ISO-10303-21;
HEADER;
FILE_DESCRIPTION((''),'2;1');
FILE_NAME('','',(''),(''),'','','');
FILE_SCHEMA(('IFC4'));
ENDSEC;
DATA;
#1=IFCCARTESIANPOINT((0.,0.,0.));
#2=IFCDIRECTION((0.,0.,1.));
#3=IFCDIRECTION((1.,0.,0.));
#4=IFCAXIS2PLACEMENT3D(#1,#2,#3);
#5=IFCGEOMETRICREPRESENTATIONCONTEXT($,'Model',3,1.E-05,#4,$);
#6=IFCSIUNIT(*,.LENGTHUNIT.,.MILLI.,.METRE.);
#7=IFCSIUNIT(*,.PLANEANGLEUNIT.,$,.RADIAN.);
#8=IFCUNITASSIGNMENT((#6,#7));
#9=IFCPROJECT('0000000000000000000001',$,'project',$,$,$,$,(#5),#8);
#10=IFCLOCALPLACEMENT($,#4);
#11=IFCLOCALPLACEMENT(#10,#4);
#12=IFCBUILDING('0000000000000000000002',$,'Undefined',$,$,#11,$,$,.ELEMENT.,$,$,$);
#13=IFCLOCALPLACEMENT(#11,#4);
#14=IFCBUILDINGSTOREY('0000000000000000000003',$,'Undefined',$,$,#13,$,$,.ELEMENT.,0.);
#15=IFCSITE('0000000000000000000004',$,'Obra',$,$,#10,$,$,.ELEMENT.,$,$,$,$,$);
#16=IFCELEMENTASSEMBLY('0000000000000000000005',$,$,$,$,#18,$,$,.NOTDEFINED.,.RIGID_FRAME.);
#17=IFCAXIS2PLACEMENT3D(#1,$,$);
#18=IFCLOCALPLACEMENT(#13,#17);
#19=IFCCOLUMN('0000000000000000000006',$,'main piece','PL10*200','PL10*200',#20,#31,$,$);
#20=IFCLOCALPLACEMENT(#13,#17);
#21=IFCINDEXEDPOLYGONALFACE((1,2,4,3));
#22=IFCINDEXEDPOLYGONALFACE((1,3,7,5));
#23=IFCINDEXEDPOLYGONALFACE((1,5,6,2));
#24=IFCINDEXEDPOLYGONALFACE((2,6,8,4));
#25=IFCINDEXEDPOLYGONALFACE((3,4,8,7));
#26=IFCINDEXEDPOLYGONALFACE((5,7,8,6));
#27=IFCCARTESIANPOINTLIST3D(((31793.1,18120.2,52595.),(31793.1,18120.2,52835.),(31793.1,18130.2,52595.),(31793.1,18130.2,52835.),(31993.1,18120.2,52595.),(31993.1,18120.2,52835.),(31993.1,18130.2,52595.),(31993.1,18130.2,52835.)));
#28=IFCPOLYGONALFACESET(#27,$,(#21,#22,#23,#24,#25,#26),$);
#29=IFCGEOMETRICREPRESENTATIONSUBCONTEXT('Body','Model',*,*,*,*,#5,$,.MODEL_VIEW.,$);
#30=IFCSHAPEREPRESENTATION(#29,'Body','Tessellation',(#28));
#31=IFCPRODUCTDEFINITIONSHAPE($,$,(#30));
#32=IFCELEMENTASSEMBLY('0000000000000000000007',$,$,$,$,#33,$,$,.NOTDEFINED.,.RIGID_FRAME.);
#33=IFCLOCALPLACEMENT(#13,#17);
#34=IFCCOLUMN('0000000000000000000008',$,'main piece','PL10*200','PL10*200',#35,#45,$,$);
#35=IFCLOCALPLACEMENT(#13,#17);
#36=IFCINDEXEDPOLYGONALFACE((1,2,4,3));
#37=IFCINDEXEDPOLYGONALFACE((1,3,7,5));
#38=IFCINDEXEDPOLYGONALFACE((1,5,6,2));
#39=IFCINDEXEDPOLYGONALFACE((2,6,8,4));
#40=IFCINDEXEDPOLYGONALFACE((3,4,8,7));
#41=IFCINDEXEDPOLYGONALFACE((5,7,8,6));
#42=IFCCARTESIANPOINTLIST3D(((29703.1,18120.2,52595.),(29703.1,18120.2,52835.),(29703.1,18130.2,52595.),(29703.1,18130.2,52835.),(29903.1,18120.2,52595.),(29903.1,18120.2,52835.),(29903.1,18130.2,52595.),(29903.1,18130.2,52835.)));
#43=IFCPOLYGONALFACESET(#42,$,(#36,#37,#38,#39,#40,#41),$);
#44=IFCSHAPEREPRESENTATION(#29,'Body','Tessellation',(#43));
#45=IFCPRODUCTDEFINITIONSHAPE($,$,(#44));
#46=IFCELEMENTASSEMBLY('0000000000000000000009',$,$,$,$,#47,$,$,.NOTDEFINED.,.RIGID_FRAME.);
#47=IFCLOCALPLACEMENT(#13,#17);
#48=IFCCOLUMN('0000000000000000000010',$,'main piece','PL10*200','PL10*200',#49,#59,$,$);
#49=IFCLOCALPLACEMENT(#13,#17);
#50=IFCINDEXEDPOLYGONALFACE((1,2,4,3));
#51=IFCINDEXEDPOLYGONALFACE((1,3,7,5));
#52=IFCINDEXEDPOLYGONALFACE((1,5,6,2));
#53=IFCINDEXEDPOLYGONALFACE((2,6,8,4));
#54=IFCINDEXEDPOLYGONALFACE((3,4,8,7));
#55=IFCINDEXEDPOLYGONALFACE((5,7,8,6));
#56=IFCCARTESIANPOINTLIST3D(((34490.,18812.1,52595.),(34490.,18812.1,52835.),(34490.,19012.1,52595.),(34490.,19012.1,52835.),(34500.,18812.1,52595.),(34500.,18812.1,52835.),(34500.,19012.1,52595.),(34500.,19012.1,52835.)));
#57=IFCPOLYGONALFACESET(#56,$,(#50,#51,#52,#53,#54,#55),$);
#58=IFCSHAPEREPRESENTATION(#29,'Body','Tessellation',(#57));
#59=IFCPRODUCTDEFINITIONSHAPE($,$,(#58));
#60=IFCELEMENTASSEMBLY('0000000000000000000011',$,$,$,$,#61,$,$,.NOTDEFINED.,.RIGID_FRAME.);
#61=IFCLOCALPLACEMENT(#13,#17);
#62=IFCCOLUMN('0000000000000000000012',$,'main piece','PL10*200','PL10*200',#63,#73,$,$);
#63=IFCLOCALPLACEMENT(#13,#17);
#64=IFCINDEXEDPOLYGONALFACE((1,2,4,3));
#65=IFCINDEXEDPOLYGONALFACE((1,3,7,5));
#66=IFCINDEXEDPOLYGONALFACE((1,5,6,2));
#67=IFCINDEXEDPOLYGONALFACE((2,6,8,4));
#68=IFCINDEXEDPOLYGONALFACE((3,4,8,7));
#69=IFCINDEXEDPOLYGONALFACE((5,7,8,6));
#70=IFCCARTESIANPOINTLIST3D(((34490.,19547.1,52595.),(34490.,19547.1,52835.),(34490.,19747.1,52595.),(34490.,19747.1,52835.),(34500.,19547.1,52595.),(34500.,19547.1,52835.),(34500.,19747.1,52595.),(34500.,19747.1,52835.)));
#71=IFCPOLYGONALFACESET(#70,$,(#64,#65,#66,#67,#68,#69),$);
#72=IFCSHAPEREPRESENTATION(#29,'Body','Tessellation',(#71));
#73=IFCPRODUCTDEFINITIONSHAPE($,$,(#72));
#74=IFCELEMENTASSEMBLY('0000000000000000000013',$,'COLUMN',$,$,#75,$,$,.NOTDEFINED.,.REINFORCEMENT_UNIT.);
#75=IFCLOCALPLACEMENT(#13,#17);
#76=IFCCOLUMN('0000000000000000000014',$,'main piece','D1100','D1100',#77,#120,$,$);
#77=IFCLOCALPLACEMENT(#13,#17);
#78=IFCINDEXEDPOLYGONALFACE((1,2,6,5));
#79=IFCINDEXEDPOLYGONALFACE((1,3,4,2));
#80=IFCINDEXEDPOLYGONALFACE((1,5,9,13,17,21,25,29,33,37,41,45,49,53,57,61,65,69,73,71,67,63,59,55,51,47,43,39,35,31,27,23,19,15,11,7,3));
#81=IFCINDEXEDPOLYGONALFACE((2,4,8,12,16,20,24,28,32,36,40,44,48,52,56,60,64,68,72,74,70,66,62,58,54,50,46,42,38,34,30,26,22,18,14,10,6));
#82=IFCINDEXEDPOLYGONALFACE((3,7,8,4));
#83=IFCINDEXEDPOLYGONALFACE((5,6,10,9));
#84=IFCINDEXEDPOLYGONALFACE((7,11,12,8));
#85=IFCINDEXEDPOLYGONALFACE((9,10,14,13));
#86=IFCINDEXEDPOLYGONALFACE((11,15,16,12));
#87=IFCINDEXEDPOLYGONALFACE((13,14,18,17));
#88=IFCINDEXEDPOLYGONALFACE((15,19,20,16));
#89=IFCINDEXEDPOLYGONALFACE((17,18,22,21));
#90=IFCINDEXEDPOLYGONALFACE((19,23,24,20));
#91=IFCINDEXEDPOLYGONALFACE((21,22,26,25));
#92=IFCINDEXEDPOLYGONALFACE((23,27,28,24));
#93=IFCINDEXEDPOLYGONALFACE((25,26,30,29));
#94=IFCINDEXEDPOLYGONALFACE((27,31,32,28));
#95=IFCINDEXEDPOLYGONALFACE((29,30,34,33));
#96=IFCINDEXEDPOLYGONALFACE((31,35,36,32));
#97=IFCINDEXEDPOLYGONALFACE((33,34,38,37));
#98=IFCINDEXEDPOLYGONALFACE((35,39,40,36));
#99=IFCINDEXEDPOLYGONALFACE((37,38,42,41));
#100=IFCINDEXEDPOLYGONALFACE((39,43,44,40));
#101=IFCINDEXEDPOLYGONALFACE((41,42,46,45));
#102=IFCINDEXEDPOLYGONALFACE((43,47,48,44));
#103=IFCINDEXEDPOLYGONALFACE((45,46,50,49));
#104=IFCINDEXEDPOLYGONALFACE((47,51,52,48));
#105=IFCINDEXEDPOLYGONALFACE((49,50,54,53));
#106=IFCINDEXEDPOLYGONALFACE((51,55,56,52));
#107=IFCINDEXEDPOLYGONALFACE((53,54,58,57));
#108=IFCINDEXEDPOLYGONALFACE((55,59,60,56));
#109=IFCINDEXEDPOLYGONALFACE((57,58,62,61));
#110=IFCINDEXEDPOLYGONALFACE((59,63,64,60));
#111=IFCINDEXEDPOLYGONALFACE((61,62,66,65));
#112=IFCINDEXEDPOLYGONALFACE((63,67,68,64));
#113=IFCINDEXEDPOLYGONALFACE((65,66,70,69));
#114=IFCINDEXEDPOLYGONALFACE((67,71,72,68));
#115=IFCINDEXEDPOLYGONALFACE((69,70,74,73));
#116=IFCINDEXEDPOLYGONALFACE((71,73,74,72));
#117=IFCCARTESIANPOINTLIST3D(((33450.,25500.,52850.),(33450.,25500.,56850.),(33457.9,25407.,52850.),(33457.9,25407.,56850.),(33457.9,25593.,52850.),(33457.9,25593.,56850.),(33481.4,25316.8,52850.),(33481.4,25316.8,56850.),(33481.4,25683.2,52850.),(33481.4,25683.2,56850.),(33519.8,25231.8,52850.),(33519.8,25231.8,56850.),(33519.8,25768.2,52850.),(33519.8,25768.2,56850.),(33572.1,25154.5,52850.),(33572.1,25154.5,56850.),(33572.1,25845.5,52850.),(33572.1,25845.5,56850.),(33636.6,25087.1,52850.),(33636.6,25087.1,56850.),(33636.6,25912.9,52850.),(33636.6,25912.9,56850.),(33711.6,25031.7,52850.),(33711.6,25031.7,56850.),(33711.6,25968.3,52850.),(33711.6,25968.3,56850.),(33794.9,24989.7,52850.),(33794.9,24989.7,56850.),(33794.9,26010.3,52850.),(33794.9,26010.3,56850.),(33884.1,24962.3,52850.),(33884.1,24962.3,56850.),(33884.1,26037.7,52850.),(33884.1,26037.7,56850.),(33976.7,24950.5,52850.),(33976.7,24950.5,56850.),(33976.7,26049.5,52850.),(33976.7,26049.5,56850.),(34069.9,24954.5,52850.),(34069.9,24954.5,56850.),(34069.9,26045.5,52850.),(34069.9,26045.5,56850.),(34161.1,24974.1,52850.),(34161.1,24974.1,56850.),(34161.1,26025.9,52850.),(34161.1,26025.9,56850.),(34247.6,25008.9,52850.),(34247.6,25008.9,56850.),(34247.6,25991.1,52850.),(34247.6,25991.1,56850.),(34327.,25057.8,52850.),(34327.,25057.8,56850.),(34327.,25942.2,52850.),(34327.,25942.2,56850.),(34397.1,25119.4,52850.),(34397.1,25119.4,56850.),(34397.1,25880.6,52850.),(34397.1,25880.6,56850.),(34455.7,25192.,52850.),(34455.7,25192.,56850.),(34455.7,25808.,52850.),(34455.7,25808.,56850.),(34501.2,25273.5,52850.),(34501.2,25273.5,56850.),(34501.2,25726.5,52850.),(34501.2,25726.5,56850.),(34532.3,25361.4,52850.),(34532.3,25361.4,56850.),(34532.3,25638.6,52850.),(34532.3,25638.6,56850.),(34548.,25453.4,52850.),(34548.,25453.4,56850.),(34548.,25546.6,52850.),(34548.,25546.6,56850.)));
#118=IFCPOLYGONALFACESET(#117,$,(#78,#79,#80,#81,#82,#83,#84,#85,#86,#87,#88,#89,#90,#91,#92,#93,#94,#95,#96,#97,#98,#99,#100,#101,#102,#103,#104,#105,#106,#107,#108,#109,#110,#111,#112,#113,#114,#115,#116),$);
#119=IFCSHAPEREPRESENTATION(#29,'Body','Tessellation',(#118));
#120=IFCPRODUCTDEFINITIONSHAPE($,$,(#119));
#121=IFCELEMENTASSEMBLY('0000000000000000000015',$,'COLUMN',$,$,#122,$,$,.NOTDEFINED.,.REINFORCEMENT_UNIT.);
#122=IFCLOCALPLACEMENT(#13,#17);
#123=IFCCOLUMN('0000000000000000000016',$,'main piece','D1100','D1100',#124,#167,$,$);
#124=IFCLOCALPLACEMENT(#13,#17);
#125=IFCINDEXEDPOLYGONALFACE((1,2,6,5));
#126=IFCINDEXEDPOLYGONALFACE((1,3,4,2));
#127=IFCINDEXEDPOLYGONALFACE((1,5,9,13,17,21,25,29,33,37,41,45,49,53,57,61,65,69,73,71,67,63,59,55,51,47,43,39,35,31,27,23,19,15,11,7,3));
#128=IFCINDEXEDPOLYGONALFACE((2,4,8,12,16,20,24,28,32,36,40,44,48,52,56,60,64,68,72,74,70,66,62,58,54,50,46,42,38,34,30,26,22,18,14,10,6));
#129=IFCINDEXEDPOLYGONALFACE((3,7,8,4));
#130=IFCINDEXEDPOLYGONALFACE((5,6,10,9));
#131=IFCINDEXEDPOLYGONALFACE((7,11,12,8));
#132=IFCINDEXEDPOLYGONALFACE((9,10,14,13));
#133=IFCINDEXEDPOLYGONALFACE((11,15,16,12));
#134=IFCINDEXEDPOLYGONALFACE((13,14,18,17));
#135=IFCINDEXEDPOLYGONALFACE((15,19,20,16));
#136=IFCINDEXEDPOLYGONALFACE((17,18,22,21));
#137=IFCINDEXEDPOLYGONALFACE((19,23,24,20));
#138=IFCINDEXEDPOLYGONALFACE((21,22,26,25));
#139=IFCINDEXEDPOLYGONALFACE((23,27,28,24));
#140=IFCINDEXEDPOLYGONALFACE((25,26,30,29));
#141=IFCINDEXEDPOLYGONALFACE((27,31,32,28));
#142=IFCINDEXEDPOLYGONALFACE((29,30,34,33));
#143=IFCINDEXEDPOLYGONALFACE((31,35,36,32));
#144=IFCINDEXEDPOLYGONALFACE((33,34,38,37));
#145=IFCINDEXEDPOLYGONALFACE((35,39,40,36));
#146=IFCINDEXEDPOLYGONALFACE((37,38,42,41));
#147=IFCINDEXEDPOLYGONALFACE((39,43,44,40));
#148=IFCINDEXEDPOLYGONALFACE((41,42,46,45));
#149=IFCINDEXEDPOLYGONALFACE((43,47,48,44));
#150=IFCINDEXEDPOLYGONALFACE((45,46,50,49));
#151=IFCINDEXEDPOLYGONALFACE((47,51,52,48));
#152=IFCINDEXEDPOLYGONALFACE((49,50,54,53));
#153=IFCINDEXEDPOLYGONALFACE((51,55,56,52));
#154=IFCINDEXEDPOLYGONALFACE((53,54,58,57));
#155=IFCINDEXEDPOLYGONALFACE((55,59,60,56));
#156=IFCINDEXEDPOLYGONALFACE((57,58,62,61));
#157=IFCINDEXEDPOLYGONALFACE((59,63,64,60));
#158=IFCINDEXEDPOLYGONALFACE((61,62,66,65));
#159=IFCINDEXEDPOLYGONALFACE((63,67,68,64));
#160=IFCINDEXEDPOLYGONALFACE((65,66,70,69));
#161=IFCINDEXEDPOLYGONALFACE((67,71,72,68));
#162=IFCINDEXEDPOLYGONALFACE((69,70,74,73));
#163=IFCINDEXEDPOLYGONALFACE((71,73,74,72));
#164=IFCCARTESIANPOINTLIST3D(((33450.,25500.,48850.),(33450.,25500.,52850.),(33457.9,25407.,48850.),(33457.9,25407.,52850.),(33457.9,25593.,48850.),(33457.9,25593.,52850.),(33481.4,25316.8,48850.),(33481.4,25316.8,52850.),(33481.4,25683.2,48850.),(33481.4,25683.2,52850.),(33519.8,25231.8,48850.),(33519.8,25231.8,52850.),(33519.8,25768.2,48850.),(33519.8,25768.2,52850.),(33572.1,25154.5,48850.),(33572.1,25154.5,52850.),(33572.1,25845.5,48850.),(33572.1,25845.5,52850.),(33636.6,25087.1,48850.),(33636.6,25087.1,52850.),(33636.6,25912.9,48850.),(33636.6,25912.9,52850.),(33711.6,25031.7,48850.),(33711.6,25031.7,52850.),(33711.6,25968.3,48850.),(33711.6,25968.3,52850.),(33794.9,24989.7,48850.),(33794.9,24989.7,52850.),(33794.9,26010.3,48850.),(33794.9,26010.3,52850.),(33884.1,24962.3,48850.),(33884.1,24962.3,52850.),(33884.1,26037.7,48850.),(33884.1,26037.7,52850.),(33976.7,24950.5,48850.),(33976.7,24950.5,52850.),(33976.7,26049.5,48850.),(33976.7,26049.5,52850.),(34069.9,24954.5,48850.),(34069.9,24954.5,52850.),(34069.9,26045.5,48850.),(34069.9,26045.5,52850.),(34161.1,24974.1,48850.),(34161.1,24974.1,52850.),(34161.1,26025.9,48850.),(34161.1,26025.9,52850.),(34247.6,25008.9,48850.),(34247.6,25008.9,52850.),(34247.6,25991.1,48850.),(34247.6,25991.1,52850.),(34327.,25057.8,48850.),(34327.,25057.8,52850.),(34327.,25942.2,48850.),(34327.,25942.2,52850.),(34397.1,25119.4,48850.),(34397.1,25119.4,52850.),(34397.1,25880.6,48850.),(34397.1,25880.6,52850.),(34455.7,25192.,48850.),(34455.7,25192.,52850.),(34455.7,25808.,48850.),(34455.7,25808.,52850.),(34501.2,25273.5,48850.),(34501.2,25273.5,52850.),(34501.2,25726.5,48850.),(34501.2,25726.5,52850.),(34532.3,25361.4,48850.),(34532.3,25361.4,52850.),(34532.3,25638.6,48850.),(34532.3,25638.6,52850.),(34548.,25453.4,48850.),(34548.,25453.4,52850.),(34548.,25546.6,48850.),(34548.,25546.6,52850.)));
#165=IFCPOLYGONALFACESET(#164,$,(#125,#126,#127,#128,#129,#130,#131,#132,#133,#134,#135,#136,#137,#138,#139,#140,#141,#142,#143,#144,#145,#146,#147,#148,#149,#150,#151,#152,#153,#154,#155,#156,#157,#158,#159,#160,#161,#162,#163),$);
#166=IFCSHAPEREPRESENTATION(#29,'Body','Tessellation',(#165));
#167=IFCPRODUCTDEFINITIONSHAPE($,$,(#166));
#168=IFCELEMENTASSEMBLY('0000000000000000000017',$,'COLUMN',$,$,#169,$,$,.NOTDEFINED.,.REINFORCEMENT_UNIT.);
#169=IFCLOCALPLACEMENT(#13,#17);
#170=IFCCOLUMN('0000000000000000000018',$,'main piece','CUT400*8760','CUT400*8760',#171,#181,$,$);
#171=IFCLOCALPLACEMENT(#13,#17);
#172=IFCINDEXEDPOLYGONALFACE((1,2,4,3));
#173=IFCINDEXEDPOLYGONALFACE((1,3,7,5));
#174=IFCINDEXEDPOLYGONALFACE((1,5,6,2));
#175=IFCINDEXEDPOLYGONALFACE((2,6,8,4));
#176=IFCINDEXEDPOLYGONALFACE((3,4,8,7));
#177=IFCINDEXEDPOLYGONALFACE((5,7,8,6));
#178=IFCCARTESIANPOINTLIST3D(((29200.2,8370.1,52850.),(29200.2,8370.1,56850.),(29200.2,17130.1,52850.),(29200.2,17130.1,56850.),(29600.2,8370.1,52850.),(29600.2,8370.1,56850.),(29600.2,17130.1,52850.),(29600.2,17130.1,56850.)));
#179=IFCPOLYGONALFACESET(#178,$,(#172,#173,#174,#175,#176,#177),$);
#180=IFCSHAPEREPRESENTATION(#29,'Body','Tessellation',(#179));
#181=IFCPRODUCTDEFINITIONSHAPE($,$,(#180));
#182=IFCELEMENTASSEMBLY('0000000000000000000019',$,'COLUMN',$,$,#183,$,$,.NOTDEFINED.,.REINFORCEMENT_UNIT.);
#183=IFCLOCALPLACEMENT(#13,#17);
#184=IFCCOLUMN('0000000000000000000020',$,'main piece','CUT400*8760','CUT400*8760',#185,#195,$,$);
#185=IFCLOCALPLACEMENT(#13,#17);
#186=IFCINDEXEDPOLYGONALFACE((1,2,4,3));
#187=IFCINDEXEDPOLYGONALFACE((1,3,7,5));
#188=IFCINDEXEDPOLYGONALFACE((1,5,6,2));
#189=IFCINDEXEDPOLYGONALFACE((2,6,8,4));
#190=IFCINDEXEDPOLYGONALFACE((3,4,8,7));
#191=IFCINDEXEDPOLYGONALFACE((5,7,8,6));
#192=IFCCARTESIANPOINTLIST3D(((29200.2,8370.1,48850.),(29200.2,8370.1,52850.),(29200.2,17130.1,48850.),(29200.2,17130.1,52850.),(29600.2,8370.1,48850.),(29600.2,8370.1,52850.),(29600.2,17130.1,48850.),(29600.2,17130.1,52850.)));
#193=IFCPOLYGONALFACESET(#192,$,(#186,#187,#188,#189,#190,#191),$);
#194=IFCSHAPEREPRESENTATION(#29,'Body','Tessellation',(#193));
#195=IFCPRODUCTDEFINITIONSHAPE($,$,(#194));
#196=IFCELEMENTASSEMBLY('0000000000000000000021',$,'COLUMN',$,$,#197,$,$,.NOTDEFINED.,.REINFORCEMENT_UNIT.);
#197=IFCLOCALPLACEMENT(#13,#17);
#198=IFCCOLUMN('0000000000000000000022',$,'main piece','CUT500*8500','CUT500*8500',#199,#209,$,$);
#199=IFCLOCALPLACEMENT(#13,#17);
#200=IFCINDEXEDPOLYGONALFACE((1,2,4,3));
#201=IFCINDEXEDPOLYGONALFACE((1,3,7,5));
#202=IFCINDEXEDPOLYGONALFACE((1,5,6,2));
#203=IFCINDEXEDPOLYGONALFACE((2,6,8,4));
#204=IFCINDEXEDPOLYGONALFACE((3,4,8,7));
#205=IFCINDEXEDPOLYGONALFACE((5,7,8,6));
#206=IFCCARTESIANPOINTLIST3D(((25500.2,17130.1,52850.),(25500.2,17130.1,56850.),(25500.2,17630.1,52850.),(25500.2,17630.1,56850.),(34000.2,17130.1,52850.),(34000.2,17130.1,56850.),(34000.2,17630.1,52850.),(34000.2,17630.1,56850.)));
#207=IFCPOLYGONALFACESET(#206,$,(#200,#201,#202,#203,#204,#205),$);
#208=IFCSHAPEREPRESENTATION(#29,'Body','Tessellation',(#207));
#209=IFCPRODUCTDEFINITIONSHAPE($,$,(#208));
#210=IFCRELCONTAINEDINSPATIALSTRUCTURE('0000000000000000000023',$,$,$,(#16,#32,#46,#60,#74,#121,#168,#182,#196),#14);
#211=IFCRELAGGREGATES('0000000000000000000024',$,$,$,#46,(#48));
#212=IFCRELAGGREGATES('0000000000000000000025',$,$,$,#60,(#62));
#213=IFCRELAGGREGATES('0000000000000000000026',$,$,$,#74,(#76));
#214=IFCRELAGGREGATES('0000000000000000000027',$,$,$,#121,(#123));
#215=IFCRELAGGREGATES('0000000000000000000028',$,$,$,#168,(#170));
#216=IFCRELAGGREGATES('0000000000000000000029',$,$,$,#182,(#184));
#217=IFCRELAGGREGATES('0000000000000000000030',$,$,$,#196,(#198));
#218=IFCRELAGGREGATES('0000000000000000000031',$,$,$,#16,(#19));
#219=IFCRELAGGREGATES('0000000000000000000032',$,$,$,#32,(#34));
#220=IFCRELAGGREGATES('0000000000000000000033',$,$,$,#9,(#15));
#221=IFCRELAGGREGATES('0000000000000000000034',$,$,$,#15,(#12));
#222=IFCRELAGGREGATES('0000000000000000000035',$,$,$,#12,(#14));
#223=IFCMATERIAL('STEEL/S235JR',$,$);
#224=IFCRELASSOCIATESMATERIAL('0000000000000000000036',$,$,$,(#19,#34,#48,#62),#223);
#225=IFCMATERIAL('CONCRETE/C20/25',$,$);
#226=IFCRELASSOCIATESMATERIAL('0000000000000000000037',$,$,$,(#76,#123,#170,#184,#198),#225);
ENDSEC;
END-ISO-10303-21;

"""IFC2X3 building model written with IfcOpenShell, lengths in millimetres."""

from ifc_helpers import new_model, si_unit, frame, origin_with_axes, origin_2d_with_axis, place, context, subcontext, project, spatial, rectangle, circle, extrude, material, element, aggregate, save


model = new_model("IFC2X3")

# Units and contexts
model_context = context("Model", 3, precision=1e-05, world=origin_with_axes())
body_context = subcontext(model_context, "Body", "Model", "MODEL_VIEW")
ifc_project = project(units=[si_unit("LENGTHUNIT", "METRE", prefix="MILLI"), si_unit("PLANEANGLEUNIT", "RADIAN")], contexts=[model_context])

# Site, building, storey
site_placement = place(None, origin_with_axes())
site = spatial("IfcSite", under=ifc_project, at=site_placement, Name="Obra", CompositionType="ELEMENT")
building_placement = place(site_placement, origin_with_axes())
building = spatial("IfcBuilding", under=site, at=building_placement, Name="Undefined", CompositionType="ELEMENT")
storey_placement = place(building_placement, origin_with_axes())
storey = spatial("IfcBuildingStorey", under=building, at=storey_placement, Name="Undefined", CompositionType="ELEMENT", Elevation=0.0)

# Element assemblies, columns
assembly_1_placement = place(storey_placement, origin_with_axes())
assembly_1 = element("IfcElementAssembly", 1, at=assembly_1_placement, inside=storey, AssemblyPlace="NOTDEFINED", PredefinedType="RIGID_FRAME")
ifc_material_1 = material(Name="STEEL/S235JR")
column_1_placement = place(assembly_1_placement, frame((31893.1, 18125.2, 52595.0), z_axis=(0.0, 0.0, 1.0), x_axis=(1.0, 0.000002, 0.0)))
column_1 = element("IfcColumn", 2, at=column_1_placement, material=ifc_material_1, Name="main piece", Description="PL10*200", ObjectType="PL10*200", context=body_context, shape_type="SweptSolid", body=[
    extrude(rectangle(XDim=10.0, YDim=200.0, at=origin_2d_with_axis()), frame((0.0, 0.0, 240.0), z_axis=(0.0, 0.0, -1.0), x_axis=(0.0, 1.0, 0.0)), (0.0, 0.0, 1.0), 240.0),
])
assembly_2_placement = place(storey_placement, origin_with_axes())
assembly_2 = element("IfcElementAssembly", 3, at=assembly_2_placement, inside=storey, AssemblyPlace="NOTDEFINED", PredefinedType="RIGID_FRAME")
column_2_placement = place(assembly_2_placement, frame((29803.1, 18125.2, 52595.0), z_axis=(0.0, 0.0, 1.0), x_axis=(1.0, 0.000002, 0.0)))
column_2 = element("IfcColumn", 4, at=column_2_placement, material=ifc_material_1, Name="main piece", Description="PL10*200", ObjectType="PL10*200", context=body_context, shape_type="SweptSolid", body=[
    extrude(rectangle(XDim=10.0, YDim=200.0, at=origin_2d_with_axis()), frame((0.0, 0.0, 240.0), z_axis=(0.0, 0.0, -1.0), x_axis=(0.0, 1.0, 0.0)), (0.0, 0.0, 1.0), 240.0),
])
assembly_3_placement = place(storey_placement, origin_with_axes())
assembly_3 = element("IfcElementAssembly", 5, at=assembly_3_placement, inside=storey, AssemblyPlace="NOTDEFINED", PredefinedType="RIGID_FRAME")
column_3_placement = place(assembly_3_placement, frame((34495.0, 18912.1, 52595.0), z_axis=(0.0, 0.0, 1.0), x_axis=(0.0, -1.0, 0.0)))
column_3 = element("IfcColumn", 6, at=column_3_placement, material=ifc_material_1, Name="main piece", Description="PL10*200", ObjectType="PL10*200", context=body_context, shape_type="SweptSolid", body=[
    extrude(rectangle(XDim=10.0, YDim=200.0, at=origin_2d_with_axis()), frame((0.0, 0.0, 240.0), z_axis=(0.0, 0.0, -1.0), x_axis=(0.0, 1.0, 0.0)), (0.0, 0.0, 1.0), 240.0),
])
aggregate(assembly_3, [column_3])
assembly_4_placement = place(storey_placement, origin_with_axes())
assembly_4 = element("IfcElementAssembly", 7, at=assembly_4_placement, inside=storey, AssemblyPlace="NOTDEFINED", PredefinedType="RIGID_FRAME")
column_4_placement = place(assembly_4_placement, frame((34495.0, 19647.1, 52595.0), z_axis=(0.0, 0.0, 1.0), x_axis=(0.0, -1.0, 0.0)))
column_4 = element("IfcColumn", 8, at=column_4_placement, material=ifc_material_1, Name="main piece", Description="PL10*200", ObjectType="PL10*200", context=body_context, shape_type="SweptSolid", body=[
    extrude(rectangle(XDim=10.0, YDim=200.0, at=origin_2d_with_axis()), frame((0.0, 0.0, 240.0), z_axis=(0.0, 0.0, -1.0), x_axis=(0.0, 1.0, 0.0)), (0.0, 0.0, 1.0), 240.0),
])
aggregate(assembly_4, [column_4])
assembly_5_placement = place(storey_placement, origin_with_axes())
assembly_5 = element("IfcElementAssembly", 9, at=assembly_5_placement, inside=storey, Name="COLUMN", AssemblyPlace="NOTDEFINED", PredefinedType="REINFORCEMENT_UNIT")
ifc_material_2 = material(Name="CONCRETE/C20/25")
column_5_placement = place(assembly_5_placement, frame((34000.0, 25500.0, 52850.0), z_axis=(0.0, 0.0, 1.0), x_axis=(0.0, 1.0, 0.0)))
column_5 = element("IfcColumn", 10, at=column_5_placement, material=ifc_material_2, Name="main piece", Description="D1100", ObjectType="D1100", context=body_context, shape_type="SweptSolid", body=[
    extrude(circle(Radius=550.0, at=origin_2d_with_axis()), frame((0.0, 0.0, 4000.0), z_axis=(0.0, 0.0, -1.0), x_axis=(0.0, 1.0, 0.0)), (0.0, 0.0, 1.0), 4000.0),
])
aggregate(assembly_5, [column_5])
assembly_6_placement = place(storey_placement, origin_with_axes())
assembly_6 = element("IfcElementAssembly", 11, at=assembly_6_placement, inside=storey, Name="COLUMN", AssemblyPlace="NOTDEFINED", PredefinedType="REINFORCEMENT_UNIT")
column_6_placement = place(assembly_6_placement, frame((34000.0, 25500.0, 48850.0), z_axis=(0.0, 0.0, 1.0), x_axis=(0.0, 1.0, 0.0)))
column_6 = element("IfcColumn", 12, at=column_6_placement, material=ifc_material_2, Name="main piece", Description="D1100", ObjectType="D1100", context=body_context, shape_type="SweptSolid", body=[
    extrude(circle(Radius=550.0, at=origin_2d_with_axis()), frame((0.0, 0.0, 4000.0), z_axis=(0.0, 0.0, -1.0), x_axis=(0.0, 1.0, 0.0)), (0.0, 0.0, 1.0), 4000.0),
])
aggregate(assembly_6, [column_6])
assembly_7_placement = place(storey_placement, origin_with_axes())
assembly_7 = element("IfcElementAssembly", 13, at=assembly_7_placement, inside=storey, Name="COLUMN", AssemblyPlace="NOTDEFINED", PredefinedType="REINFORCEMENT_UNIT")
column_7_placement = place(assembly_7_placement, frame((29400.2, 12750.1, 52850.0), z_axis=(0.0, 0.0, 1.0), x_axis=(0.0, -1.0, 0.0)))
column_7 = element("IfcColumn", 14, at=column_7_placement, material=ifc_material_2, Name="main piece", Description="CUT400*8760", ObjectType="CUT400*8760", context=body_context, shape_type="SweptSolid", body=[
    extrude(rectangle(XDim=400.0, YDim=8760.0, at=origin_2d_with_axis()), frame((0.0, 0.0, 4000.0), z_axis=(0.0, 0.0, -1.0), x_axis=(0.0, 1.0, 0.0)), (0.0, 0.0, 1.0), 4000.0),
])
aggregate(assembly_7, [column_7])
assembly_8_placement = place(storey_placement, origin_with_axes())
assembly_8 = element("IfcElementAssembly", 15, at=assembly_8_placement, inside=storey, Name="COLUMN", AssemblyPlace="NOTDEFINED", PredefinedType="REINFORCEMENT_UNIT")
column_8_placement = place(assembly_8_placement, frame((29400.2, 12750.1, 48850.0), z_axis=(0.0, 0.0, 1.0), x_axis=(0.0, -1.0, 0.0)))
column_8 = element("IfcColumn", 16, at=column_8_placement, material=ifc_material_2, Name="main piece", Description="CUT400*8760", ObjectType="CUT400*8760", context=body_context, shape_type="SweptSolid", body=[
    extrude(rectangle(XDim=400.0, YDim=8760.0, at=origin_2d_with_axis()), frame((0.0, 0.0, 4000.0), z_axis=(0.0, 0.0, -1.0), x_axis=(0.0, 1.0, 0.0)), (0.0, 0.0, 1.0), 4000.0),
])
aggregate(assembly_8, [column_8])
assembly_9_placement = place(storey_placement, origin_with_axes())
assembly_9 = element("IfcElementAssembly", 17, at=assembly_9_placement, inside=storey, Name="COLUMN", AssemblyPlace="NOTDEFINED", PredefinedType="REINFORCEMENT_UNIT")
column_9_placement = place(assembly_9_placement, frame((29750.2, 17380.1, 52850.0), z_axis=(0.0, 0.0, 1.0), x_axis=(-1.0, 0.0, 0.0)))
column_9 = element("IfcColumn", 18, at=column_9_placement, material=ifc_material_2, Name="main piece", Description="CUT500*8500", ObjectType="CUT500*8500", context=body_context, shape_type="SweptSolid", body=[
    extrude(rectangle(XDim=500.0, YDim=8500.0, at=origin_2d_with_axis()), frame((0.0, 0.0, 4000.0), z_axis=(0.0, 0.0, -1.0), x_axis=(0.0, 1.0, 0.0)), (0.0, 0.0, 1.0), 4000.0),
])
aggregate(assembly_9, [column_9])

aggregate(assembly_1, [column_1])
aggregate(assembly_2, [column_2])

save(model, "model.ifc")
